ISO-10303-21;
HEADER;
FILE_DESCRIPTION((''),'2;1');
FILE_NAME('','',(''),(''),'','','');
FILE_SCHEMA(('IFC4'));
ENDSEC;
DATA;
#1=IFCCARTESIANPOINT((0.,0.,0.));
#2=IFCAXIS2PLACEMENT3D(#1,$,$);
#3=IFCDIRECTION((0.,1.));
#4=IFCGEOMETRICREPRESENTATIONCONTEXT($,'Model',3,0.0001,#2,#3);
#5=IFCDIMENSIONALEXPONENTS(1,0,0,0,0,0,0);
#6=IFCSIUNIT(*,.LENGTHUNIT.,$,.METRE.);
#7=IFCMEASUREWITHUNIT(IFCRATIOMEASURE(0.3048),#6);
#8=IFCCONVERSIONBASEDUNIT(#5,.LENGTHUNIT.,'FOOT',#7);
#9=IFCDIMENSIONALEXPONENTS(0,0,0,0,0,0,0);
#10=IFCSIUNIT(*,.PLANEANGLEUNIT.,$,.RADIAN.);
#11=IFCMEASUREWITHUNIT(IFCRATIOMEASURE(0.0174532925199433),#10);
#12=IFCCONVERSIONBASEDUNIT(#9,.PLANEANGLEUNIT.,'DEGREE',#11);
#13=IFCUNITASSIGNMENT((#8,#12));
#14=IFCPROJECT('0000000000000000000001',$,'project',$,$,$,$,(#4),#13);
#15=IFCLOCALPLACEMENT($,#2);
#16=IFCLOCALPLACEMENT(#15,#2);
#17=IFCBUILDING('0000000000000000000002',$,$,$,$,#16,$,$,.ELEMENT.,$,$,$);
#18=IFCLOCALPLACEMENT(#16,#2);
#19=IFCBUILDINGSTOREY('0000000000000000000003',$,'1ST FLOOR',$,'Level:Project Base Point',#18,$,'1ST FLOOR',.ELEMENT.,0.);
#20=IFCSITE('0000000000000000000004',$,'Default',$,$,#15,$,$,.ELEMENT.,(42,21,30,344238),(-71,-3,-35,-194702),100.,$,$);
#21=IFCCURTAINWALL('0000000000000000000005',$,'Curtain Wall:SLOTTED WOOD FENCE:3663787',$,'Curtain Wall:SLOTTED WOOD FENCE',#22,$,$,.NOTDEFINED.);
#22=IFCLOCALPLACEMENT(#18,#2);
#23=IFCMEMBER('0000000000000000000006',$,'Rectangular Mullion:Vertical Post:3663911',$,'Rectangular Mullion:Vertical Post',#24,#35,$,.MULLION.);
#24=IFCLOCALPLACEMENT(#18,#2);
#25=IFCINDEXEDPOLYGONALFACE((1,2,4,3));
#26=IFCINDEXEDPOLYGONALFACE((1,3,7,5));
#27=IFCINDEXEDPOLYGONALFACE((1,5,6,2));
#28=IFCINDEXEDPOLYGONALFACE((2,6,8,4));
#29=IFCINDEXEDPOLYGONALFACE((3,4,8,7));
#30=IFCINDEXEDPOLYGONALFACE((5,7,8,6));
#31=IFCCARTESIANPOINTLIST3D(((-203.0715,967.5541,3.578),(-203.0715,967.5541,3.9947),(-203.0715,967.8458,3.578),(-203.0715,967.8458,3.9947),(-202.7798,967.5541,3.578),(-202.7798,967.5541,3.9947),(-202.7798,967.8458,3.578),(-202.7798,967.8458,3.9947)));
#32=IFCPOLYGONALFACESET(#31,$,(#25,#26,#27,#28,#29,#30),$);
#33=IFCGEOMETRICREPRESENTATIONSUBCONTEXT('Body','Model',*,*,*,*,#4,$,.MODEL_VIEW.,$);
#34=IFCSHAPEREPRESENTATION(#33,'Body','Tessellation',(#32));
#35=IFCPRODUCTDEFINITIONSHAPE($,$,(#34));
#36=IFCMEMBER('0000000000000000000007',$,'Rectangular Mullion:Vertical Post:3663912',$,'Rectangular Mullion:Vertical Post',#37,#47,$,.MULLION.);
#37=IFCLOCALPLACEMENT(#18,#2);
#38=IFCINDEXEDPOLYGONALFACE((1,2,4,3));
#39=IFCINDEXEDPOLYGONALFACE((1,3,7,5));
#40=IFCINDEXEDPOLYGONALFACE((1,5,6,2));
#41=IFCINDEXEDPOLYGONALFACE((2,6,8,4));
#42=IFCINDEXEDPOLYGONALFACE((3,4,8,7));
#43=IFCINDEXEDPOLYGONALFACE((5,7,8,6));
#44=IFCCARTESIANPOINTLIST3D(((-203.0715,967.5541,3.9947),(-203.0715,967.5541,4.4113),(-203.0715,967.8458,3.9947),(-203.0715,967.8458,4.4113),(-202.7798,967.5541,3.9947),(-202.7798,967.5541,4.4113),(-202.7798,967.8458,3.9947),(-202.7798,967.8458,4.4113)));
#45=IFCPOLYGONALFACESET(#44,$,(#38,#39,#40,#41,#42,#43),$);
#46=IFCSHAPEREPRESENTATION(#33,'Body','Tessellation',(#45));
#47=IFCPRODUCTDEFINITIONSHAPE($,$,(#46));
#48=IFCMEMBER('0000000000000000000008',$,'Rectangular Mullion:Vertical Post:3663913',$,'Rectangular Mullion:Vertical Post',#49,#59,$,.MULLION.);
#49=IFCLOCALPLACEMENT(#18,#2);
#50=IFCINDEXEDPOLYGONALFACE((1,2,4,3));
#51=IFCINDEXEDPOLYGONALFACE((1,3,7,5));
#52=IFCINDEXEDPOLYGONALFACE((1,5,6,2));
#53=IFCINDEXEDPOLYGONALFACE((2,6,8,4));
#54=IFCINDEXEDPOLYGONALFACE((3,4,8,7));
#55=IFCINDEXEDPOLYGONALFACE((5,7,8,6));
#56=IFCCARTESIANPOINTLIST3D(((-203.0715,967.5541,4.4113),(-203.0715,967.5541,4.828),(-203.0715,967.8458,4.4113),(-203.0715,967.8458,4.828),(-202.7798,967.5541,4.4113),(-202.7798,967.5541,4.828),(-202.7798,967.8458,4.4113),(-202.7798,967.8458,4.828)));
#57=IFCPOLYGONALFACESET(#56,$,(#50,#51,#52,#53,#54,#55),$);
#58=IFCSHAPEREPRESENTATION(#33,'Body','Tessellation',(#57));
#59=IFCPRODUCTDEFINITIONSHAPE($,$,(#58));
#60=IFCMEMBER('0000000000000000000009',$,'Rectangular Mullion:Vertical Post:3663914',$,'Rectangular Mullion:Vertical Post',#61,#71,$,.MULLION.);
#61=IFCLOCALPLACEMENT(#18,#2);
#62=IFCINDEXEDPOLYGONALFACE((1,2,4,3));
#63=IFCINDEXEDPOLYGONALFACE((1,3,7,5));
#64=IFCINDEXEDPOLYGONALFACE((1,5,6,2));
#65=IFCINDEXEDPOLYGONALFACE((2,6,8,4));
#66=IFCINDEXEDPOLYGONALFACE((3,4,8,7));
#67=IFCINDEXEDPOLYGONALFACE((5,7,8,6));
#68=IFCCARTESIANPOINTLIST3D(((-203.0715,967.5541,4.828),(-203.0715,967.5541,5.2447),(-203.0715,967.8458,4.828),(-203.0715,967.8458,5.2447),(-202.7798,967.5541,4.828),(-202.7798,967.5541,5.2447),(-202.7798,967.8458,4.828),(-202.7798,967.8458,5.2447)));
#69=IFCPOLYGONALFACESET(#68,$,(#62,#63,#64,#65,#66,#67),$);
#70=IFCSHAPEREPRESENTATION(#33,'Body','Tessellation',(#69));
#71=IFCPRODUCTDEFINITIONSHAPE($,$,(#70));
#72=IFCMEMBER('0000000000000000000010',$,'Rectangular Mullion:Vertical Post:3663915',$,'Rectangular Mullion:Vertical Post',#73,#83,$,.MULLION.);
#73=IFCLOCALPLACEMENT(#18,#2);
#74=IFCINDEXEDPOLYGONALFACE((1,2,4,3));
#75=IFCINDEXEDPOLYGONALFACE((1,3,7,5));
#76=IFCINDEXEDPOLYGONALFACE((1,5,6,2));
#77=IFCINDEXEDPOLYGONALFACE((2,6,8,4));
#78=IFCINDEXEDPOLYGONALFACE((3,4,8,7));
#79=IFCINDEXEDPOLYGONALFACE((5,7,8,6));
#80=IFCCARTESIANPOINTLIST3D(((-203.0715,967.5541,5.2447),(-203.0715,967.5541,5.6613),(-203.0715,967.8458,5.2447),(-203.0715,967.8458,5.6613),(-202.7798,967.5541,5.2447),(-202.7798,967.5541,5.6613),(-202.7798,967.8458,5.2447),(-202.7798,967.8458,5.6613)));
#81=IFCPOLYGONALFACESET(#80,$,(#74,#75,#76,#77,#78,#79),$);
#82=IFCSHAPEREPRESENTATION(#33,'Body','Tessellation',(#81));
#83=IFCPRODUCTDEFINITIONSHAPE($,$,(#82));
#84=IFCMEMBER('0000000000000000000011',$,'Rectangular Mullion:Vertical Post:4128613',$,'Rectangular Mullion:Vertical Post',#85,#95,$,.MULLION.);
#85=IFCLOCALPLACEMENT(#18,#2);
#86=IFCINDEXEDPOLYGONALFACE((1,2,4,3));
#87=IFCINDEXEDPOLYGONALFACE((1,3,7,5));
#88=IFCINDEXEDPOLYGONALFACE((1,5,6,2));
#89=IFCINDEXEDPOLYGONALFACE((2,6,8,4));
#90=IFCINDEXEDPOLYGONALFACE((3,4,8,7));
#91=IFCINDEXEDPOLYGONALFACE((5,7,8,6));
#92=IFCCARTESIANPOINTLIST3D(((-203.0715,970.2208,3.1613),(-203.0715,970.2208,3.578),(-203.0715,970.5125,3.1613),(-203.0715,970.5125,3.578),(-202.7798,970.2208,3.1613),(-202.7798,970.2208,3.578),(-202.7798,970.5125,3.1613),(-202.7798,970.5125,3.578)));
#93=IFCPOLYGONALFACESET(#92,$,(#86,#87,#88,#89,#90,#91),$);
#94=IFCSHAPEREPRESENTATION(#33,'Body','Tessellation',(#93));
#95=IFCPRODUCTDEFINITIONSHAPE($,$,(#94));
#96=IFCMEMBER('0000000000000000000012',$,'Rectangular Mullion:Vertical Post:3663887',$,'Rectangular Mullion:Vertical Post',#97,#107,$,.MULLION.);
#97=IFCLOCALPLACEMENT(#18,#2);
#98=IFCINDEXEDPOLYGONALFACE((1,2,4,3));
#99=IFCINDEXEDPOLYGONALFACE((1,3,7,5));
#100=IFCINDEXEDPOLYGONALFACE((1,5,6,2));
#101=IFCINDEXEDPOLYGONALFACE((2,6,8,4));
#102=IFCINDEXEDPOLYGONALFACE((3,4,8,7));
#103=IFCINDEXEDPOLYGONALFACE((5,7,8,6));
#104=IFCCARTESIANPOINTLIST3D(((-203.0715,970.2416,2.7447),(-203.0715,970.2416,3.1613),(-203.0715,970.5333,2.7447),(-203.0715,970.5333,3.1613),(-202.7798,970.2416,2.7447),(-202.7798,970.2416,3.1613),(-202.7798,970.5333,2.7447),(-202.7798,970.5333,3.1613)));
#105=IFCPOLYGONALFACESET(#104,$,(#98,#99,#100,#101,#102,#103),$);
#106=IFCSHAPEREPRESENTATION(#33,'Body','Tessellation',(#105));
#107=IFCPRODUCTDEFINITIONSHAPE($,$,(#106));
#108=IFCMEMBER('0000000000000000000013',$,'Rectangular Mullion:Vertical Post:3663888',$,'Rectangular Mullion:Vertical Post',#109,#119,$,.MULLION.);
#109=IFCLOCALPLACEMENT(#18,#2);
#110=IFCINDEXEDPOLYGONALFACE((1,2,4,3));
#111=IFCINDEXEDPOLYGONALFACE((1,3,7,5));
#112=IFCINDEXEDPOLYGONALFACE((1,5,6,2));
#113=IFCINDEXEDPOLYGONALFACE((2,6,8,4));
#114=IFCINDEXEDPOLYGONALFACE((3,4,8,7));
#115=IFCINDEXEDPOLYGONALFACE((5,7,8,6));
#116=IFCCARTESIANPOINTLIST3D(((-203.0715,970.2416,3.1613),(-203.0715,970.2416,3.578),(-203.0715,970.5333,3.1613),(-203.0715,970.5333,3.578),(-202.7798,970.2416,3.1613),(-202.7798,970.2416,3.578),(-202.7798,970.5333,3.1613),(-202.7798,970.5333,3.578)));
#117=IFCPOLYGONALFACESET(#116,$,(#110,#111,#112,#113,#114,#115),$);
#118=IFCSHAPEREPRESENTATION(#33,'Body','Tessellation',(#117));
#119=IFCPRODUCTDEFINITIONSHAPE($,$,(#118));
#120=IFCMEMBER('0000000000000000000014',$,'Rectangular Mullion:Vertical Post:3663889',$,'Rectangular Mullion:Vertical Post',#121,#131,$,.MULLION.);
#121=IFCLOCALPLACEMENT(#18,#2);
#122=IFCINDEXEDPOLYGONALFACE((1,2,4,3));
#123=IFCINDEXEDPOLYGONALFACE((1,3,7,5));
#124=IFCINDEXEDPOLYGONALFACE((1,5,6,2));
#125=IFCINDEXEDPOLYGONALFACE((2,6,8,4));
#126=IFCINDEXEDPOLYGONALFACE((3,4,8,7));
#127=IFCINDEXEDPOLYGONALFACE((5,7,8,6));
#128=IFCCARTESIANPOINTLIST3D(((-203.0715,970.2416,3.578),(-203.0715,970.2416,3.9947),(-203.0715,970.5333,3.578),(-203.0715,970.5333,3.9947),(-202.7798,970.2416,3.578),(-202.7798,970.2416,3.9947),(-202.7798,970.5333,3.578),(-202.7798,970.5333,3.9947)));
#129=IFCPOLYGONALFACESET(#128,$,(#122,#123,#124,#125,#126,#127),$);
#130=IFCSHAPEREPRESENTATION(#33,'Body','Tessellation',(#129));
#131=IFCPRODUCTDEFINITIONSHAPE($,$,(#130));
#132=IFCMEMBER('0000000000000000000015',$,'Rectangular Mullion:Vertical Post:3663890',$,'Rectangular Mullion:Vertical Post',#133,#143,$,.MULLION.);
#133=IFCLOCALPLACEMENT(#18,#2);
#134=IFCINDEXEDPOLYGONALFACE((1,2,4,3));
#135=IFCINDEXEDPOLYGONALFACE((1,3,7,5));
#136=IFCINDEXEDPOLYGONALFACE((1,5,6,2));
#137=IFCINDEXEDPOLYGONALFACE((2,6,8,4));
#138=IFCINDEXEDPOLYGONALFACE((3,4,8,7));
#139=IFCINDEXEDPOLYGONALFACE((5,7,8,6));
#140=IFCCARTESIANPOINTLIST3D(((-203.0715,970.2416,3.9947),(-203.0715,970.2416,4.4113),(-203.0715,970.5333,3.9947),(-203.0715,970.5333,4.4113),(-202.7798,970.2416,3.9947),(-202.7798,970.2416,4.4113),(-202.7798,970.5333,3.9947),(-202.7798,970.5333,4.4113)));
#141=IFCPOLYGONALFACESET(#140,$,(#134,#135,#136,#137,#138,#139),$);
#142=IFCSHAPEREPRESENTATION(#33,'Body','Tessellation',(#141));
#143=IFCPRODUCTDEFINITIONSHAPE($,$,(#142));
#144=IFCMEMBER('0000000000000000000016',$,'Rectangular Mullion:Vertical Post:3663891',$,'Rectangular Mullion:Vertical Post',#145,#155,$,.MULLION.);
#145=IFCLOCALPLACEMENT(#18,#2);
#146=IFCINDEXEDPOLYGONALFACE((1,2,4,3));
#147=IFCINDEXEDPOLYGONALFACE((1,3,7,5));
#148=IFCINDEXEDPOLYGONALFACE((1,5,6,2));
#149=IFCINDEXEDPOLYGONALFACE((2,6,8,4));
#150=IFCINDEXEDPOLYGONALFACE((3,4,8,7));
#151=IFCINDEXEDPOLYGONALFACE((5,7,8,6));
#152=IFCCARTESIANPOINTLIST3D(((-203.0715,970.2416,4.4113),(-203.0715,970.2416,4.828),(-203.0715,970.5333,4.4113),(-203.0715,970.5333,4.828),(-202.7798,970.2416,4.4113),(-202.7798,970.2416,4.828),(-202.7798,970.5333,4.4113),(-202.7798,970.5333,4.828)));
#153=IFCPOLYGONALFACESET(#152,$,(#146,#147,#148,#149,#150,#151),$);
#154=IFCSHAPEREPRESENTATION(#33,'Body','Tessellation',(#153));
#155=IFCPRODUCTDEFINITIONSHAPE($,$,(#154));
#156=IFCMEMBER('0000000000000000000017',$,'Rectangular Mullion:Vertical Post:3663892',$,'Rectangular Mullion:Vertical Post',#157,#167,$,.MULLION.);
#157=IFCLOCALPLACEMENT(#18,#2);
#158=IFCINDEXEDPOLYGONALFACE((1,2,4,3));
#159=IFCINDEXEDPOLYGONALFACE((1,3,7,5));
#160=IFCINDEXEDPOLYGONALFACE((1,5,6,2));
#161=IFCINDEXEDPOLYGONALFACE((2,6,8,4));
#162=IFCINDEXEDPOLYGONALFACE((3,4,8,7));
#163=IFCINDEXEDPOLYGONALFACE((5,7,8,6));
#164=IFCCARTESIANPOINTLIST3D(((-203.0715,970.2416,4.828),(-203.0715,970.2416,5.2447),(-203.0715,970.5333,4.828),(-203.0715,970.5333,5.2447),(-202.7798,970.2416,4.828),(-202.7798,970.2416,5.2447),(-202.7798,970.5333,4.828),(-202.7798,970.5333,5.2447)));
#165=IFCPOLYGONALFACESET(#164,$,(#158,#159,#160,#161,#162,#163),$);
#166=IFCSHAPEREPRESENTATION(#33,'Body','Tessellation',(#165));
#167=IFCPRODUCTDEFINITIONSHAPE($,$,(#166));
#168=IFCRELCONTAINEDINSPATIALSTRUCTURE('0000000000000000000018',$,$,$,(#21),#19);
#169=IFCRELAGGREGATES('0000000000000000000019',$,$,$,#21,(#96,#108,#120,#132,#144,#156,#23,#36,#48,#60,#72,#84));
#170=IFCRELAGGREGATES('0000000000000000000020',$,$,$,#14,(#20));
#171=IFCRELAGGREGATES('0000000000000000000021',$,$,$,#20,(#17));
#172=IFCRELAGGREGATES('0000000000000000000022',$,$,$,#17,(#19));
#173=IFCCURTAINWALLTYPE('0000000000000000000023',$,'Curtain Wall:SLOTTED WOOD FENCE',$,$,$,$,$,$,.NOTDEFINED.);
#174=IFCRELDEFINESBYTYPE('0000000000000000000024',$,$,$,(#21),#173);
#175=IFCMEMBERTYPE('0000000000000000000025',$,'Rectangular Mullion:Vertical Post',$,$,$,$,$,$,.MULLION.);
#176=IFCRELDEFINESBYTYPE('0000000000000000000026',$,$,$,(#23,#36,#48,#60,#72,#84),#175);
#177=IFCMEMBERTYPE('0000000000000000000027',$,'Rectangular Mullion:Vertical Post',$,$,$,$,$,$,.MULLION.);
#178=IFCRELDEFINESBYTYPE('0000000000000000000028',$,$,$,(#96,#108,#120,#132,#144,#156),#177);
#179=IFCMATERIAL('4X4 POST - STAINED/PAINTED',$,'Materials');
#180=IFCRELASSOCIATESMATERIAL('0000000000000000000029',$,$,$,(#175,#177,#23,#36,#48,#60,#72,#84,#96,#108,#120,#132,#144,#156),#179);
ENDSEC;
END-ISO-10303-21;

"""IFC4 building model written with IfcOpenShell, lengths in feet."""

from ifc_helpers import new_model, entity, si_unit, converted_unit, direction, frame, origin, origin_2d_with_axis, place, context, subcontext, project, spatial, rectangle, extrude, source, transform, mapped, material, material_profile, profile_set, profile_usage, type_object, type_shapes, element, aggregate, save


model = new_model("IFC4")

# Units and contexts
model_context = context("Model", 3, precision=0.0001, world=origin(), true_north=direction((0.0, 1.0)))
body_context = subcontext(model_context, "Body", "Model", "MODEL_VIEW")
ifc_project = project(units=[converted_unit("LENGTHUNIT", "FOOT", entity("IfcRatioMeasure", 0.3048), si_unit("LENGTHUNIT", "METRE"), dimensions=[1, 0, 0, 0, 0, 0, 0]), converted_unit("PLANEANGLEUNIT", "DEGREE", entity("IfcRatioMeasure", 0.0174532925199433), si_unit("PLANEANGLEUNIT", "RADIAN"), dimensions=[0, 0, 0, 0, 0, 0, 0])], contexts=[model_context])

# Site, building, storey
site_placement = place(None, origin())
site = spatial("IfcSite", under=ifc_project, at=site_placement, Name="Default", CompositionType="ELEMENT", RefLatitude=(42, 21, 30, 344238), RefLongitude=(-71, -3, -35, -194702), RefElevation=100.0)
building_placement = place(site_placement, origin())
building = spatial("IfcBuilding", under=site, at=building_placement, CompositionType="ELEMENT")
storey_placement = place(building_placement, origin())
storey = spatial("IfcBuildingStorey", under=building, at=storey_placement, Name="1ST FLOOR", ObjectType="Level:Project Base Point", LongName="1ST FLOOR", CompositionType="ELEMENT", Elevation=0.0)

# Curtain wall, members
curtain_wall_type = type_object("IfcCurtainWallType", Name="Curtain Wall:SLOTTED WOOD FENCE", PredefinedType="NOTDEFINED")
curtain_wall_placement = place(storey_placement, origin())
curtain_wall = element("IfcCurtainWall", 1, at=curtain_wall_placement, inside=storey, type_object=curtain_wall_type, Name="Curtain Wall:SLOTTED WOOD FENCE:3663787", ObjectType="Curtain Wall:SLOTTED WOOD FENCE", PredefinedType="NOTDEFINED")
ifc_material_1 = material(Name="4X4 POST - STAINED/PAINTED", Category="Materials")
ifc_material_profile = material_profile(ifc_material_1, rectangle(XDim=0.2917, YDim=0.2917, at=origin_2d_with_axis()), Name="Vertical Post")
ifc_profile_set = profile_set([ifc_material_profile], Name="Vertical Post")
ifc_profile_usage_1 = profile_usage(ifc_profile_set)
member_type_1 = type_object("IfcMemberType", Name="Rectangular Mullion:Vertical Post", PredefinedType="MULLION", material=ifc_profile_set)
shared_shape_1 = source(origin(), body_context, "Body", "SweptSolid", [
    extrude(rectangle(XDim=0.2917, YDim=0.2917, at=origin_2d_with_axis()), frame((0.0, -0.2083, -0.4167), z_axis=(0.0, 0.0, 1.0), x_axis=(0.0, -1.0, 0.0)), (0.0, 0.0, 1.0), 0.4167),
])
type_shapes(member_type_1, [shared_shape_1])
member_1_placement = place(storey_placement, frame((-203.134, 967.7, 3.578), z_axis=(0.0, 0.0, -1.0), x_axis=(0.0, -1.0, 0.0)))
member_1 = element("IfcMember", 2, at=member_1_placement, type_object=member_type_1, material=ifc_profile_usage_1, Name="Rectangular Mullion:Vertical Post:3663911", ObjectType="Rectangular Mullion:Vertical Post", PredefinedType="MULLION", context=body_context, shape_type="MappedRepresentation", body=[
    mapped(shared_shape_1, transform((0.0, 0.0, 0.0), scale=1.0)),
])
ifc_profile_usage_2 = profile_usage(ifc_profile_set)
member_2_placement = place(storey_placement, frame((-203.134, 967.7, 3.9947), z_axis=(0.0, 0.0, -1.0), x_axis=(0.0, -1.0, 0.0)))
member_2 = element("IfcMember", 3, at=member_2_placement, type_object=member_type_1, material=ifc_profile_usage_2, Name="Rectangular Mullion:Vertical Post:3663912", ObjectType="Rectangular Mullion:Vertical Post", PredefinedType="MULLION", context=body_context, shape_type="MappedRepresentation", body=[
    mapped(shared_shape_1, transform((0.0, 0.0, 0.0), scale=1.0)),
])
ifc_profile_usage_3 = profile_usage(ifc_profile_set)
member_3_placement = place(storey_placement, frame((-203.134, 967.7, 4.4113), z_axis=(0.0, 0.0, -1.0), x_axis=(0.0, -1.0, 0.0)))
member_3 = element("IfcMember", 4, at=member_3_placement, type_object=member_type_1, material=ifc_profile_usage_3, Name="Rectangular Mullion:Vertical Post:3663913", ObjectType="Rectangular Mullion:Vertical Post", PredefinedType="MULLION", context=body_context, shape_type="MappedRepresentation", body=[
    mapped(shared_shape_1, transform((0.0, 0.0, 0.0), scale=1.0)),
])
ifc_profile_usage_4 = profile_usage(ifc_profile_set)
member_4_placement = place(storey_placement, frame((-203.134, 967.7, 4.828), z_axis=(0.0, 0.0, -1.0), x_axis=(0.0, -1.0, 0.0)))
member_4 = element("IfcMember", 5, at=member_4_placement, type_object=member_type_1, material=ifc_profile_usage_4, Name="Rectangular Mullion:Vertical Post:3663914", ObjectType="Rectangular Mullion:Vertical Post", PredefinedType="MULLION", context=body_context, shape_type="MappedRepresentation", body=[
    mapped(shared_shape_1, transform((0.0, 0.0, 0.0), scale=1.0)),
])
ifc_profile_usage_5 = profile_usage(ifc_profile_set)
member_5_placement = place(storey_placement, frame((-203.134, 967.7, 5.2447), z_axis=(0.0, 0.0, -1.0), x_axis=(0.0, -1.0, 0.0)))
member_5 = element("IfcMember", 6, at=member_5_placement, type_object=member_type_1, material=ifc_profile_usage_5, Name="Rectangular Mullion:Vertical Post:3663915", ObjectType="Rectangular Mullion:Vertical Post", PredefinedType="MULLION", context=body_context, shape_type="MappedRepresentation", body=[
    mapped(shared_shape_1, transform((0.0, 0.0, 0.0), scale=1.0)),
])
ifc_profile_usage_6 = profile_usage(ifc_profile_set)
member_6_placement = place(storey_placement, frame((-203.134, 970.3666, 3.1613), z_axis=(0.0, 0.0, -1.0), x_axis=(0.0, -1.0, 0.0)))
member_6 = element("IfcMember", 7, at=member_6_placement, type_object=member_type_1, material=ifc_profile_usage_6, Name="Rectangular Mullion:Vertical Post:4128613", ObjectType="Rectangular Mullion:Vertical Post", PredefinedType="MULLION", context=body_context, shape_type="MappedRepresentation", body=[
    mapped(shared_shape_1, transform((0.0, 0.0, 0.0), scale=1.0)),
])
ifc_profile_usage_7 = profile_usage(ifc_profile_set)
member_type_2 = type_object("IfcMemberType", Name="Rectangular Mullion:Vertical Post", PredefinedType="MULLION", material=ifc_profile_set)
shared_shape_2 = source(origin(), body_context, "Body", "SweptSolid", [
    extrude(rectangle(XDim=0.2917, YDim=0.2917, at=origin_2d_with_axis()), frame((-0.1458, -0.2083, -0.4167), z_axis=(0.0, 0.0, 1.0), x_axis=(0.0, -1.0, 0.0)), (0.0, 0.0, 1.0), 0.4167),
])
type_shapes(member_type_2, [shared_shape_2])
member_7_placement = place(storey_placement, frame((-203.134, 970.5333, 3.1613), z_axis=(0.0, 0.0, 1.0), x_axis=(0.0, 1.0, 0.0)))
member_7 = element("IfcMember", 8, at=member_7_placement, type_object=member_type_2, material=ifc_profile_usage_7, Name="Rectangular Mullion:Vertical Post:3663887", ObjectType="Rectangular Mullion:Vertical Post", PredefinedType="MULLION", context=body_context, shape_type="MappedRepresentation", body=[
    mapped(shared_shape_2, transform((0.0, 0.0, 0.0), scale=1.0)),
])
ifc_profile_usage_8 = profile_usage(ifc_profile_set)
member_8_placement = place(storey_placement, frame((-203.134, 970.5333, 3.578), z_axis=(0.0, 0.0, 1.0), x_axis=(0.0, 1.0, 0.0)))
member_8 = element("IfcMember", 9, at=member_8_placement, type_object=member_type_2, material=ifc_profile_usage_8, Name="Rectangular Mullion:Vertical Post:3663888", ObjectType="Rectangular Mullion:Vertical Post", PredefinedType="MULLION", context=body_context, shape_type="MappedRepresentation", body=[
    mapped(shared_shape_2, transform((0.0, 0.0, 0.0), scale=1.0)),
])
ifc_profile_usage_9 = profile_usage(ifc_profile_set)
member_9_placement = place(storey_placement, frame((-203.134, 970.5333, 3.9947), z_axis=(0.0, 0.0, 1.0), x_axis=(0.0, 1.0, 0.0)))
member_9 = element("IfcMember", 10, at=member_9_placement, type_object=member_type_2, material=ifc_profile_usage_9, Name="Rectangular Mullion:Vertical Post:3663889", ObjectType="Rectangular Mullion:Vertical Post", PredefinedType="MULLION", context=body_context, shape_type="MappedRepresentation", body=[
    mapped(shared_shape_2, transform((0.0, 0.0, 0.0), scale=1.0)),
])
ifc_profile_usage_10 = profile_usage(ifc_profile_set)
member_10_placement = place(storey_placement, frame((-203.134, 970.5333, 4.4113), z_axis=(0.0, 0.0, 1.0), x_axis=(0.0, 1.0, 0.0)))
member_10 = element("IfcMember", 11, at=member_10_placement, type_object=member_type_2, material=ifc_profile_usage_10, Name="Rectangular Mullion:Vertical Post:3663890", ObjectType="Rectangular Mullion:Vertical Post", PredefinedType="MULLION", context=body_context, shape_type="MappedRepresentation", body=[
    mapped(shared_shape_2, transform((0.0, 0.0, 0.0), scale=1.0)),
])
ifc_profile_usage_11 = profile_usage(ifc_profile_set)
member_11_placement = place(storey_placement, frame((-203.134, 970.5333, 4.828), z_axis=(0.0, 0.0, 1.0), x_axis=(0.0, 1.0, 0.0)))
member_11 = element("IfcMember", 12, at=member_11_placement, type_object=member_type_2, material=ifc_profile_usage_11, Name="Rectangular Mullion:Vertical Post:3663891", ObjectType="Rectangular Mullion:Vertical Post", PredefinedType="MULLION", context=body_context, shape_type="MappedRepresentation", body=[
    mapped(shared_shape_2, transform((0.0, 0.0, 0.0), scale=1.0)),
])
ifc_profile_usage_12 = profile_usage(ifc_profile_set)
member_12_placement = place(storey_placement, frame((-203.134, 970.5333, 5.2447), z_axis=(0.0, 0.0, 1.0), x_axis=(0.0, 1.0, 0.0)))
member_12 = element("IfcMember", 13, at=member_12_placement, type_object=member_type_2, material=ifc_profile_usage_12, Name="Rectangular Mullion:Vertical Post:3663892", ObjectType="Rectangular Mullion:Vertical Post", PredefinedType="MULLION", context=body_context, shape_type="MappedRepresentation", body=[
    mapped(shared_shape_2, transform((0.0, 0.0, 0.0), scale=1.0)),
])
aggregate(curtain_wall, [member_7, member_8, member_9, member_10, member_11, member_12, member_1, member_2, member_3, member_4, member_5, member_6])

save(model, "model.ifc")
